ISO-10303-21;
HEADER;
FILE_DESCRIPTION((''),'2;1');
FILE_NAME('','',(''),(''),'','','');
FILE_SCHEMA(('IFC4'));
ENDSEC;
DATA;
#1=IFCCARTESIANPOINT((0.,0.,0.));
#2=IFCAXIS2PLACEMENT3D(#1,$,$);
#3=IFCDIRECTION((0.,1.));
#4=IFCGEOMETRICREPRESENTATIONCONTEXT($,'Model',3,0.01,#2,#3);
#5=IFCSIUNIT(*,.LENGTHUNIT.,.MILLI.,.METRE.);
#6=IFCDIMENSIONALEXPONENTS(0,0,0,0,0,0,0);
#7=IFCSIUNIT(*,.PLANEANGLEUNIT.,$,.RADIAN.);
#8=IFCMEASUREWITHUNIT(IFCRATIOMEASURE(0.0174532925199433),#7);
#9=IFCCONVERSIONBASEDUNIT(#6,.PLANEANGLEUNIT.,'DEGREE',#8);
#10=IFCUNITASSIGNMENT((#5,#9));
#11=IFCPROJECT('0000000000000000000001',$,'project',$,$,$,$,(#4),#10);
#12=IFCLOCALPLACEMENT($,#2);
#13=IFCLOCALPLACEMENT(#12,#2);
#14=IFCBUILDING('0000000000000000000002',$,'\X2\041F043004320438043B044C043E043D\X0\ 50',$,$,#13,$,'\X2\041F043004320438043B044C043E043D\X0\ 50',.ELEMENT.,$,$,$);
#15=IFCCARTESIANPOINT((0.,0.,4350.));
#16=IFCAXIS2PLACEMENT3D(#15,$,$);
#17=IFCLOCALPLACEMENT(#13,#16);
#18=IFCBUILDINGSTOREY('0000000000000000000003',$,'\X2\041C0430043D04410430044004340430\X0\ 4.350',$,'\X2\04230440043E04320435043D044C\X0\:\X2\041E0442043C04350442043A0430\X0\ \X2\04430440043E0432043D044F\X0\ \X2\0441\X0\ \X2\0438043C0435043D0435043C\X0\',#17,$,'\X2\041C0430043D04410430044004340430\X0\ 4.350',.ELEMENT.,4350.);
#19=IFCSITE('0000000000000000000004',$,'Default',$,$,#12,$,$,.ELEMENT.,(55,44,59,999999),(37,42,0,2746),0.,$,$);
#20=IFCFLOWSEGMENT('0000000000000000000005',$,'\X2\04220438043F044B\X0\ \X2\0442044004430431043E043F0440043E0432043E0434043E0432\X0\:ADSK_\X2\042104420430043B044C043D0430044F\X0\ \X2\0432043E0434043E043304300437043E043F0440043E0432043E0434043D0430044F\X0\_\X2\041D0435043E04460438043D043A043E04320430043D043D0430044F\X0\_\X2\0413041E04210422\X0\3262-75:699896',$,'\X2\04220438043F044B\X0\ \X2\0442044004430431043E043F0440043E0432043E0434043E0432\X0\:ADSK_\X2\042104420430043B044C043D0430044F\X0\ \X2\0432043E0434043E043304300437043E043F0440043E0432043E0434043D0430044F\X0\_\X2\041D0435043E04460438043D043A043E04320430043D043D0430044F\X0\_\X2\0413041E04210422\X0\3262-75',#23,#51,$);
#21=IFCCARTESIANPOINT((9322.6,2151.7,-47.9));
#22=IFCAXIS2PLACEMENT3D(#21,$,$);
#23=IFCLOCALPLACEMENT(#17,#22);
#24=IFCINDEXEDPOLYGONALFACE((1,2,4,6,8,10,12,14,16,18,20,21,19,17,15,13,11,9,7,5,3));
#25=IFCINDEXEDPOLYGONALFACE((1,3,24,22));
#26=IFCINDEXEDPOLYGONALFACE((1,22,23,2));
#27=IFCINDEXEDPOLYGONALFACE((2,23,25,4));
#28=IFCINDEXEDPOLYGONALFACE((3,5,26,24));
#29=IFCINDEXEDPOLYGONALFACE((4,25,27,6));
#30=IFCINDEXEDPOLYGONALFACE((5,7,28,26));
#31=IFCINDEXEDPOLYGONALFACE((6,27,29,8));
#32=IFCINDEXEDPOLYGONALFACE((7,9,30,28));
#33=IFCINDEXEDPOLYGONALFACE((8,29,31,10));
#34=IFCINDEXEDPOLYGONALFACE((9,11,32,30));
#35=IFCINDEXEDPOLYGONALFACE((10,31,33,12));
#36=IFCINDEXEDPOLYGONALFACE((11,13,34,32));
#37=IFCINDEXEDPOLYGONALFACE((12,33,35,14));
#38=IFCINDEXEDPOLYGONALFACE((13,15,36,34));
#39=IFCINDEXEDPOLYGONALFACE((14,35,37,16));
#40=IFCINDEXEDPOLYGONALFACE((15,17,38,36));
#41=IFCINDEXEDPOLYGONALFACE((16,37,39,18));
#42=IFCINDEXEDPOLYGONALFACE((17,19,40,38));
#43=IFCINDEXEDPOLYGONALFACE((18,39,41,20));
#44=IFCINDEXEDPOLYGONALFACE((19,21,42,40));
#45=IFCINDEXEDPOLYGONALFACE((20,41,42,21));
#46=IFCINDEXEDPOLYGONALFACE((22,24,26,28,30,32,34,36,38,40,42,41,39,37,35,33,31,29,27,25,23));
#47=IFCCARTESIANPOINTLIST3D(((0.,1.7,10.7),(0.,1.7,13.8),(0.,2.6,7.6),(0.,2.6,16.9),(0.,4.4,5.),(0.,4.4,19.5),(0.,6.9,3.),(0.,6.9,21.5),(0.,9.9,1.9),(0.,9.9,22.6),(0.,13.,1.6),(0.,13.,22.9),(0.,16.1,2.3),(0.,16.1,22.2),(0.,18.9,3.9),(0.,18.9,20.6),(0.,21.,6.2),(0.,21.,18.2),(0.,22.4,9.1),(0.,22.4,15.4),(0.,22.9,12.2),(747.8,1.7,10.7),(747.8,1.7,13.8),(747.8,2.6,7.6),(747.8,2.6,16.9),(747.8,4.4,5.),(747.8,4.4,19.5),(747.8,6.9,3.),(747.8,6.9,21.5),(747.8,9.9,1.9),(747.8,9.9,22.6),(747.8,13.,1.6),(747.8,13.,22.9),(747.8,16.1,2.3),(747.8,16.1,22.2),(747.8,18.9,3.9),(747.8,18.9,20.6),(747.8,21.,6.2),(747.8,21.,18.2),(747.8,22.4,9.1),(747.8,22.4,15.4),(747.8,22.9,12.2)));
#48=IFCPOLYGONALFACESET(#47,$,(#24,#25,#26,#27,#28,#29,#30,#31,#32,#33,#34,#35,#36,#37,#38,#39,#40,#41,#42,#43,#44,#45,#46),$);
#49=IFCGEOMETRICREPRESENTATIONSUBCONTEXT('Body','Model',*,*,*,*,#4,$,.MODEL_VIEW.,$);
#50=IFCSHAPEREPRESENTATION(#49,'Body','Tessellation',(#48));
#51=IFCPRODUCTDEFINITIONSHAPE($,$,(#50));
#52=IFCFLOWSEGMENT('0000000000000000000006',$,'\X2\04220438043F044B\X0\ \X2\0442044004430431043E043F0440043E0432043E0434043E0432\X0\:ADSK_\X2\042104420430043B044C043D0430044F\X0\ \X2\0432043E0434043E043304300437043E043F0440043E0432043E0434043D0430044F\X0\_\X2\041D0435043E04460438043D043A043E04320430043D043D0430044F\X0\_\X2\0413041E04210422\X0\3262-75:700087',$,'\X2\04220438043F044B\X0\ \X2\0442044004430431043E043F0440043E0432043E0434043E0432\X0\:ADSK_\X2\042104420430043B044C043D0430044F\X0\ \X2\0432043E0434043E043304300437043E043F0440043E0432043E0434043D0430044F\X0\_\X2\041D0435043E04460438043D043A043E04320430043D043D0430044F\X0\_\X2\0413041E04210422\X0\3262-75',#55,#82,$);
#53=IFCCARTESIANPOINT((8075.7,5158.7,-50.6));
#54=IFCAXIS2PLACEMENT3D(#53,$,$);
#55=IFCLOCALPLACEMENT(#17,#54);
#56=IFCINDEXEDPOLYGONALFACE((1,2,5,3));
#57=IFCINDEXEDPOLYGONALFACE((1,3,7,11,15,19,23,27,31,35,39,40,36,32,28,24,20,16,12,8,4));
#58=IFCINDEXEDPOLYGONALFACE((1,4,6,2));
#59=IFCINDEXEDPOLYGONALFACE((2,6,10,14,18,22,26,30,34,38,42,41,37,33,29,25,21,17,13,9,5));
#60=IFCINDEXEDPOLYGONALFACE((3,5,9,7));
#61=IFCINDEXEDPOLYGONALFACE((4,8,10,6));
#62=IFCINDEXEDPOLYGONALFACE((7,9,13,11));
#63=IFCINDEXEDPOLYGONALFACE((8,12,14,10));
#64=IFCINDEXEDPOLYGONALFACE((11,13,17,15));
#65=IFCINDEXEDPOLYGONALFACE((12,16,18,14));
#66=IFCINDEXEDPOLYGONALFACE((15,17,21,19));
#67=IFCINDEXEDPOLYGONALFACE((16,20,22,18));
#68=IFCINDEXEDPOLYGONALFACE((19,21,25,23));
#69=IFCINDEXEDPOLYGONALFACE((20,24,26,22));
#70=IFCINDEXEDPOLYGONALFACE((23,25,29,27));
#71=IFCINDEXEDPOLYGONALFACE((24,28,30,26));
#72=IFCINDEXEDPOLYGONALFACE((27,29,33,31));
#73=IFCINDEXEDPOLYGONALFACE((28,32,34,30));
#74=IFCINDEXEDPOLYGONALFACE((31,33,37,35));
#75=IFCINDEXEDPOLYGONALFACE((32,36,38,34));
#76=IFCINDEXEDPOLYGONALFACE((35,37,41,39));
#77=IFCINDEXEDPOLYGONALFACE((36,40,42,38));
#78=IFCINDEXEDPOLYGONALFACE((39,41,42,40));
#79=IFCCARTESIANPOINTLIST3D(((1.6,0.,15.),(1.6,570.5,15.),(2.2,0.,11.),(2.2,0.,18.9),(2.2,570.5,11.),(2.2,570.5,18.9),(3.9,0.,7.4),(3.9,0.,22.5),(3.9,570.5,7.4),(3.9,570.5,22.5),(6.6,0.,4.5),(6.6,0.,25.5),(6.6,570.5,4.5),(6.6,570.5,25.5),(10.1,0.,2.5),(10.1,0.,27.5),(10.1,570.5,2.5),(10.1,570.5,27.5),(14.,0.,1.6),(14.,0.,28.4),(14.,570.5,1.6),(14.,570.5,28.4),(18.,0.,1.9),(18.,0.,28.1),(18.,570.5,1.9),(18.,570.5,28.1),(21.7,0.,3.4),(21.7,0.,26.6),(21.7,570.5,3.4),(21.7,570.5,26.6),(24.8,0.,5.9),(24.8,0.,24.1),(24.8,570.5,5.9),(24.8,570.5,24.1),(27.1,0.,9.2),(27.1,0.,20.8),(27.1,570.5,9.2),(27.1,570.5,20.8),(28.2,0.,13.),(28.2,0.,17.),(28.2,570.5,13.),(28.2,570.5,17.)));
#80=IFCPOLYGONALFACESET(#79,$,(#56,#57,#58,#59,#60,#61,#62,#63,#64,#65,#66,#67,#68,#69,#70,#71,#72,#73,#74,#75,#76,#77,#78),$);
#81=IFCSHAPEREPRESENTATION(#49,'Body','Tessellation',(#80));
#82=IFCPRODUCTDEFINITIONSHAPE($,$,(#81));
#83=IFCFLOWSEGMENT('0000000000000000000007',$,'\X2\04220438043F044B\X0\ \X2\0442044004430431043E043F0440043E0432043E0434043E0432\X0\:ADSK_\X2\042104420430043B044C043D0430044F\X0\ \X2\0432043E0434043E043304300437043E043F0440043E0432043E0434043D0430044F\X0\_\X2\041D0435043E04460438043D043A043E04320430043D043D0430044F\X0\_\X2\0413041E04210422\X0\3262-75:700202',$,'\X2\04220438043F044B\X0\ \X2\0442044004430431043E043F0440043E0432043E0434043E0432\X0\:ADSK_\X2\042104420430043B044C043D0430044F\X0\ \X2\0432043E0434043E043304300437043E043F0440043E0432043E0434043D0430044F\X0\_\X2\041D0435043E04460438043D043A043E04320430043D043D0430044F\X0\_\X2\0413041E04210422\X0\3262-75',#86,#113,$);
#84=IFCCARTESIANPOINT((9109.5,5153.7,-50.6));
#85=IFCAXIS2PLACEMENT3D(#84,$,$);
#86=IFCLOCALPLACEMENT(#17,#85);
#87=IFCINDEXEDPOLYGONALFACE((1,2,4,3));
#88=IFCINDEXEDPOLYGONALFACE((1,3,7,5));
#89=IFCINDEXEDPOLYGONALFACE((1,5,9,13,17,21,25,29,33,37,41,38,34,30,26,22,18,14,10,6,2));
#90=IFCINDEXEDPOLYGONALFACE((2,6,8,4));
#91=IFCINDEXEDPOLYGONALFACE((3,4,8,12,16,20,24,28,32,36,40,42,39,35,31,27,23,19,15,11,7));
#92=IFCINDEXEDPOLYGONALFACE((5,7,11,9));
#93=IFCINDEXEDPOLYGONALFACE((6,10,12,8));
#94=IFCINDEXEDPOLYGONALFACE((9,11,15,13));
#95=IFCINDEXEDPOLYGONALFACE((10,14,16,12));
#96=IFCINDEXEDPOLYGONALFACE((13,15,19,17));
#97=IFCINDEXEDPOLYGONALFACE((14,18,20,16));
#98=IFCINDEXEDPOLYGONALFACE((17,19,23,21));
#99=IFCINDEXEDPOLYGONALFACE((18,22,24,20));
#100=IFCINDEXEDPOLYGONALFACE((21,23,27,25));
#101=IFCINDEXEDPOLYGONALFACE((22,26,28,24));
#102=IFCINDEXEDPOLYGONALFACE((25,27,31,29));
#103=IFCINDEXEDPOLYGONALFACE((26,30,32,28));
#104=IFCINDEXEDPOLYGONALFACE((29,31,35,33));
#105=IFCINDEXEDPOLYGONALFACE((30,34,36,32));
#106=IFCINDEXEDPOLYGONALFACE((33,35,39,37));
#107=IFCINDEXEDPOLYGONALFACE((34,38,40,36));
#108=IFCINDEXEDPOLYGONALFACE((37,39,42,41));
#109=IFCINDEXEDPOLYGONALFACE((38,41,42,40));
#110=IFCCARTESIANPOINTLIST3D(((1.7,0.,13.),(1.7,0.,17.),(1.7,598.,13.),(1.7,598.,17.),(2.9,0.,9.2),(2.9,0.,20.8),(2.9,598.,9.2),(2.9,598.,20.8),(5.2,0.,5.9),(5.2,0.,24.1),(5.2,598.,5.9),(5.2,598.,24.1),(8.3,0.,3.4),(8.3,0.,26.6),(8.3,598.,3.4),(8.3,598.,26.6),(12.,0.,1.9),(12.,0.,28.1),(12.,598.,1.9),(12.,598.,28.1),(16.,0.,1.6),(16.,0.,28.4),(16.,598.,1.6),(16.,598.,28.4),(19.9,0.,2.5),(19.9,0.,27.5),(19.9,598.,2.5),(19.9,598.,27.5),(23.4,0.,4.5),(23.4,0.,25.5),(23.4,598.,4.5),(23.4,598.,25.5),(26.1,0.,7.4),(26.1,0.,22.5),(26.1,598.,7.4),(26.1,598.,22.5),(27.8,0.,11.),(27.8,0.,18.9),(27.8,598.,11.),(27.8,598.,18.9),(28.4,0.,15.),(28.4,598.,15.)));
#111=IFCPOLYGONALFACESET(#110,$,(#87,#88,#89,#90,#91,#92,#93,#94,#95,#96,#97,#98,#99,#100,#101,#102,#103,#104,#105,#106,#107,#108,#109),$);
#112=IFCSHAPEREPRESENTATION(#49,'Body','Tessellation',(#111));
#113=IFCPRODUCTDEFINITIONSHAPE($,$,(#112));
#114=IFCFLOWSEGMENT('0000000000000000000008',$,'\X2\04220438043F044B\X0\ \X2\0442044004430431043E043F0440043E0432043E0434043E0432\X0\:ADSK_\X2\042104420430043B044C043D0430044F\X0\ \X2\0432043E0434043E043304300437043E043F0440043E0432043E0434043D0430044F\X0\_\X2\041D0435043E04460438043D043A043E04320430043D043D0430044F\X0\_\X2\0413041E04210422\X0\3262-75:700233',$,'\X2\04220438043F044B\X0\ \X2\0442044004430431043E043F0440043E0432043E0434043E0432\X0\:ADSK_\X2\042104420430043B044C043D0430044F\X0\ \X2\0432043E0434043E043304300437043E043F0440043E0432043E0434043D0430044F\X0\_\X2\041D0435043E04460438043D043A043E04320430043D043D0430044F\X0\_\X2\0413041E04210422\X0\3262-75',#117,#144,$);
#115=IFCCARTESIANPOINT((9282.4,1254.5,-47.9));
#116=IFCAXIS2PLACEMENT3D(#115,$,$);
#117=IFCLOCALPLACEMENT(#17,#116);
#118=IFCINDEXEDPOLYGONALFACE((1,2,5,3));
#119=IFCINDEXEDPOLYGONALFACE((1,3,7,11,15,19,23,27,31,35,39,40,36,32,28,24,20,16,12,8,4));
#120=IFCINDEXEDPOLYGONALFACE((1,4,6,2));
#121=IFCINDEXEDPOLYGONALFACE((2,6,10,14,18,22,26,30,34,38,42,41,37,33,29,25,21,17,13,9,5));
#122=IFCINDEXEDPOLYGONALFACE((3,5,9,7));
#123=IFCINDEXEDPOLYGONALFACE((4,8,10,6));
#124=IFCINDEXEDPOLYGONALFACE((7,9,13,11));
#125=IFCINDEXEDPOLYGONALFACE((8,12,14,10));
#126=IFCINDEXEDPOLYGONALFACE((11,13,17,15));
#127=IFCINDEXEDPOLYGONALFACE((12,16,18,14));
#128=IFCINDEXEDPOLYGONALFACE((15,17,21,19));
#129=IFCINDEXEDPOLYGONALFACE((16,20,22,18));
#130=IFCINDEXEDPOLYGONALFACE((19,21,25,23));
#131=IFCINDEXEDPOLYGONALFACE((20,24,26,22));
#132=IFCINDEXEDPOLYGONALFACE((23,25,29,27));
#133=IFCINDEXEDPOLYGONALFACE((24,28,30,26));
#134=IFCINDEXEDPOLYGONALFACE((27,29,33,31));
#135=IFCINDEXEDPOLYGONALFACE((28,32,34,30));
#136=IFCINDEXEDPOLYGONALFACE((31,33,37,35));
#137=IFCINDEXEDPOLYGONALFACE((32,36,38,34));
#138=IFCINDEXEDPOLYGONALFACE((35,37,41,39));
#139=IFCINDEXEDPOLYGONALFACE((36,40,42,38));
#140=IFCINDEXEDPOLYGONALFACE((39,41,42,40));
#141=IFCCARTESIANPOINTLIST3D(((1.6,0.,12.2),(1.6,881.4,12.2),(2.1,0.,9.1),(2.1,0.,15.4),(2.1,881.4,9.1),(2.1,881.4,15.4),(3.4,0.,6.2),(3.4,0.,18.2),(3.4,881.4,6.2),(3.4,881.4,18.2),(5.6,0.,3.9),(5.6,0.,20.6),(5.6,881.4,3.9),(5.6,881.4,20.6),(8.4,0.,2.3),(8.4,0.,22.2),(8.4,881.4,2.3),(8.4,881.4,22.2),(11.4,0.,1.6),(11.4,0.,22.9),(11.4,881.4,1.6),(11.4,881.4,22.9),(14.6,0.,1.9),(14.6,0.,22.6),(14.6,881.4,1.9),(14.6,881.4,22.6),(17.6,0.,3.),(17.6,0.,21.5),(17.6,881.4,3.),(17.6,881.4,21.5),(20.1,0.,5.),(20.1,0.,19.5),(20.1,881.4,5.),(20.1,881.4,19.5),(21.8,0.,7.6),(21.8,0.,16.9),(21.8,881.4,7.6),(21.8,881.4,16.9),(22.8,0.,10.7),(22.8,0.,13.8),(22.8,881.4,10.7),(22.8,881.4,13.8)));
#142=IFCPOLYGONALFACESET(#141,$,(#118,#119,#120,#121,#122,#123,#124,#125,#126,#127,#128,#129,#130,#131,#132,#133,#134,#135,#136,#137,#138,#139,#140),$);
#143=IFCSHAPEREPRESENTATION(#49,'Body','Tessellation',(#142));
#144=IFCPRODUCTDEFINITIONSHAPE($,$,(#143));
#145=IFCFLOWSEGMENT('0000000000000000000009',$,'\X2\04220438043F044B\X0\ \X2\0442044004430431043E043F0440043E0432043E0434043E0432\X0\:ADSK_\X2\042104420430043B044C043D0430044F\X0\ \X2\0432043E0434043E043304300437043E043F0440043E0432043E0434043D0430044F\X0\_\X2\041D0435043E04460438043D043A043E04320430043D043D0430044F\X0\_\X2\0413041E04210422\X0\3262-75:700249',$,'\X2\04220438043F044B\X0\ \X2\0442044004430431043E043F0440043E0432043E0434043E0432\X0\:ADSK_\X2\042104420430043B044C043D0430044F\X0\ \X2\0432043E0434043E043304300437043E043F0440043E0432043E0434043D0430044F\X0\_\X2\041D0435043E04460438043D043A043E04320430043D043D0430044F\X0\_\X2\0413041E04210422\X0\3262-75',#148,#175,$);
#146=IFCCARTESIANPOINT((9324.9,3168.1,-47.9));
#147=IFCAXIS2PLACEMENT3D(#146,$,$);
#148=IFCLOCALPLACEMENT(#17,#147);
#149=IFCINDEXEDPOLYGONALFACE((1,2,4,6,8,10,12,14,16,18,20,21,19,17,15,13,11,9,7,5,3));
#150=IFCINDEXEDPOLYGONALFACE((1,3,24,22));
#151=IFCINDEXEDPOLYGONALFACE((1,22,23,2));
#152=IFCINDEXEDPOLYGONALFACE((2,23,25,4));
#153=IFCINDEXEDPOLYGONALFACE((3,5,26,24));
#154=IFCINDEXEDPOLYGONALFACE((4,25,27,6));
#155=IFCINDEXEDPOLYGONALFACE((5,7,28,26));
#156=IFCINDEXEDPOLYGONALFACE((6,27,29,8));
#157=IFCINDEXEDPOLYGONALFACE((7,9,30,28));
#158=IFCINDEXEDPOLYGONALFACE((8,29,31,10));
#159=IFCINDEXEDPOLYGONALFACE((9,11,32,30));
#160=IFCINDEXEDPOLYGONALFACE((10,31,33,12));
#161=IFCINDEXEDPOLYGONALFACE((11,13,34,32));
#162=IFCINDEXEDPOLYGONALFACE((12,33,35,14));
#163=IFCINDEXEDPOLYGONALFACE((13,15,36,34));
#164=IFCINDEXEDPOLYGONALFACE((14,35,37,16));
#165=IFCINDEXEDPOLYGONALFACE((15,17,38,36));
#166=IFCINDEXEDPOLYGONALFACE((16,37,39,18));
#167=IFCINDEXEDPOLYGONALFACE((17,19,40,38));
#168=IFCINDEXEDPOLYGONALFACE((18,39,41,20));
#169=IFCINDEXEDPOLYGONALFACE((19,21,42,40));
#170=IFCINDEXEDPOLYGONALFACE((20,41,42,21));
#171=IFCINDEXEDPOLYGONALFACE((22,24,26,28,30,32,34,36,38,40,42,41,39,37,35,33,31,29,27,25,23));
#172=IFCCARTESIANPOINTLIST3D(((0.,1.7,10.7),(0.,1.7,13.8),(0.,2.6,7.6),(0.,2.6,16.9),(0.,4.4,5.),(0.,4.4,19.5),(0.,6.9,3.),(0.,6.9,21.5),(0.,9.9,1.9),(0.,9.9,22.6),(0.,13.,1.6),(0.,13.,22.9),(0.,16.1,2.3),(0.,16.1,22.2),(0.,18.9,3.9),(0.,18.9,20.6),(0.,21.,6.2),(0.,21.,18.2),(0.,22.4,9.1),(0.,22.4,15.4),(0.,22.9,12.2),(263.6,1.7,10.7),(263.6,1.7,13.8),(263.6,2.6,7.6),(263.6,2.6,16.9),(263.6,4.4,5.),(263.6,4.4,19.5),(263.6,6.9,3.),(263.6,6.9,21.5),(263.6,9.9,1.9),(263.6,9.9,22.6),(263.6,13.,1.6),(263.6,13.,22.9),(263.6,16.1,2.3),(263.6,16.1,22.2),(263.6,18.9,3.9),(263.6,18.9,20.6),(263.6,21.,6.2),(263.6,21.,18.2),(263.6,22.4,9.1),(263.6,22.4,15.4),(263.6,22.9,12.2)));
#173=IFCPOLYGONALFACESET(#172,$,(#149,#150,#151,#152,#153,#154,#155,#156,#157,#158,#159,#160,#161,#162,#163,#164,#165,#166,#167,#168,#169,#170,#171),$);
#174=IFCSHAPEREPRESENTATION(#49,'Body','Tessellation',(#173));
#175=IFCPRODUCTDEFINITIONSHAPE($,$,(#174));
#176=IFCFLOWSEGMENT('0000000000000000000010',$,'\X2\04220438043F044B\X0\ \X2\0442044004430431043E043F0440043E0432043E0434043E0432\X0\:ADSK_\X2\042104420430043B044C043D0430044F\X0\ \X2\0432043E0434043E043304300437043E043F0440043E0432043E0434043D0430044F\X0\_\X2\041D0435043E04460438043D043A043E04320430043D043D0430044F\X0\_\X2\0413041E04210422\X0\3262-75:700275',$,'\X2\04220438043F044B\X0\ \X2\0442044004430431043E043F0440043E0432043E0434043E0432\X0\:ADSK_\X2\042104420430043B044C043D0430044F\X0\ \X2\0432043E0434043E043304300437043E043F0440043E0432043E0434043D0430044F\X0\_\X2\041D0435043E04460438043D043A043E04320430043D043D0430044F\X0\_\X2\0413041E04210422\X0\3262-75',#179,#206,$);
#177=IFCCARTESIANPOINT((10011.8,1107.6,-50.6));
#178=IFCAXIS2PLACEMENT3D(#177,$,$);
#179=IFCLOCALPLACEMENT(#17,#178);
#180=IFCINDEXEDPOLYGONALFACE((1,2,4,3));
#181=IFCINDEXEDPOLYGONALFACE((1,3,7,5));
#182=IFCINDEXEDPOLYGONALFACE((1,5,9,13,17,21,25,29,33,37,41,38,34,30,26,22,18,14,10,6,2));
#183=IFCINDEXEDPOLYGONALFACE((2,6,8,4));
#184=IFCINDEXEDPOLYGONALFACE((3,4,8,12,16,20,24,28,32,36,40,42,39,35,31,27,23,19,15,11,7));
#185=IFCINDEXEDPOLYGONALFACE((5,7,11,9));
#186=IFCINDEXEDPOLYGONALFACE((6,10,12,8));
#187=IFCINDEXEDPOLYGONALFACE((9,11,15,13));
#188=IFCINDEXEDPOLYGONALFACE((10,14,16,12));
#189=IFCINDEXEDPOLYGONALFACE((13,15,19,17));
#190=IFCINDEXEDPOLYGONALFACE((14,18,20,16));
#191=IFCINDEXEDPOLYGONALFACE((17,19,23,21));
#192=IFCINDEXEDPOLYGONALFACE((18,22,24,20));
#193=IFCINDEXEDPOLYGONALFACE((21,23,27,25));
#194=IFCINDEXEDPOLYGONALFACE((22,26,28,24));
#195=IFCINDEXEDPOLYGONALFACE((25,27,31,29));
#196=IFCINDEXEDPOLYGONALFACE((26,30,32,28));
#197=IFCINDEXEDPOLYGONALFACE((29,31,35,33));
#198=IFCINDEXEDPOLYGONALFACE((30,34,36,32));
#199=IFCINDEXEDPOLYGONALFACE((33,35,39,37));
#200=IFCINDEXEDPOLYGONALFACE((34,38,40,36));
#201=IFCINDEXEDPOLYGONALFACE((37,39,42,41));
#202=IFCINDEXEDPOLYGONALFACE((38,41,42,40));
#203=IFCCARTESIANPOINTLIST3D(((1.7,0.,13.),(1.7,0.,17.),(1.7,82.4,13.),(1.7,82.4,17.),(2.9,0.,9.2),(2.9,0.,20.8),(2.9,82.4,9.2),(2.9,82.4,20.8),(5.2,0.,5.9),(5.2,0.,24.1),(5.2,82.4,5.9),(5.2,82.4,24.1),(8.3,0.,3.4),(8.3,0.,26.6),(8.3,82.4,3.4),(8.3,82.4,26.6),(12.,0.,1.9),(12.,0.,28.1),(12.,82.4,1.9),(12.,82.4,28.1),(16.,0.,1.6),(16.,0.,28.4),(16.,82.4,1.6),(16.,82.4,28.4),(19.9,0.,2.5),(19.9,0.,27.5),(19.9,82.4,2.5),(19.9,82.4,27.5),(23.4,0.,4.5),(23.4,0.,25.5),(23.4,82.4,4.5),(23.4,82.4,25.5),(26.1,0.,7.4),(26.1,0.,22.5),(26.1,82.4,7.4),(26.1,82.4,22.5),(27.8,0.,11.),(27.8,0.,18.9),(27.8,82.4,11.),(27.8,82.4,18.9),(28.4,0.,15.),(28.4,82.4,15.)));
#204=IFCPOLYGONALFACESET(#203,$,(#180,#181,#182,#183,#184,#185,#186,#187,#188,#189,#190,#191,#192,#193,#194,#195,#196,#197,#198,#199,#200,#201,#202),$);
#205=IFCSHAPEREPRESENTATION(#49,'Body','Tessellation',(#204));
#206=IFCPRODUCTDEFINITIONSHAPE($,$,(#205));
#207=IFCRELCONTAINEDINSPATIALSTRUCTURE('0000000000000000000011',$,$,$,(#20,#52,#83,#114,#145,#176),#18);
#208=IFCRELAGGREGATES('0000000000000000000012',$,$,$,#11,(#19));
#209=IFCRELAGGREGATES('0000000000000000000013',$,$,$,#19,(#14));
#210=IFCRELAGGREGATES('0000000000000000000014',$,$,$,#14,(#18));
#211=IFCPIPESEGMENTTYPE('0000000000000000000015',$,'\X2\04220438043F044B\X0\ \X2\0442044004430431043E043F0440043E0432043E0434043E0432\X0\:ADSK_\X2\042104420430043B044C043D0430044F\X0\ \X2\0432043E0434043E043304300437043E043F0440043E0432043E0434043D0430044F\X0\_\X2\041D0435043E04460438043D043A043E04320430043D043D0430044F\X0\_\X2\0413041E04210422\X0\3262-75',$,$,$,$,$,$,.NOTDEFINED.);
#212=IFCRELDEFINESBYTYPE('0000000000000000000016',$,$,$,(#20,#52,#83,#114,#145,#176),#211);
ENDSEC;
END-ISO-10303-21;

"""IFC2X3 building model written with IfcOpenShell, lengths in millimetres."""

from ifc_helpers import new_model, entity, si_unit, converted_unit, direction, frame, frame_2d, origin, origin_2d_with_axis, place, context, subcontext, project, spatial, circle, extrude, type_object, element, save


model = new_model("IFC2X3")

# Units and contexts
model_context = context("Model", 3, precision=0.01, world=origin(), true_north=direction((0.0, 1.0)))
body_context = subcontext(model_context, "Body", "Model", "MODEL_VIEW")
ifc_project = project(units=[si_unit("LENGTHUNIT", "METRE", prefix="MILLI"), converted_unit("PLANEANGLEUNIT", "DEGREE", entity("IfcRatioMeasure", 0.0174532925199433), si_unit("PLANEANGLEUNIT", "RADIAN"), dimensions=[0, 0, 0, 0, 0, 0, 0])], contexts=[model_context])

# Site, building, storey
site_placement = place(None, origin())
site = spatial("IfcSite", under=ifc_project, at=site_placement, Name="Default", CompositionType="ELEMENT", RefLatitude=(55, 44, 59, 999999), RefLongitude=(37, 42, 0, 2746), RefElevation=0.0)
building_placement = place(site_placement, origin())
building = spatial("IfcBuilding", under=site, at=building_placement, Name="Павильон 50", LongName="Павильон 50", CompositionType="ELEMENT")
storey_placement = place(building_placement, frame((0.0, 0.0, 4350.0)))
storey = spatial("IfcBuildingStorey", under=building, at=storey_placement, Name="Мансарда 4.350", ObjectType="Уровень:Отметка уровня с именем", LongName="Мансарда 4.350", CompositionType="ELEMENT", Elevation=4350.0)

# Flow segments
pipe_segment_type = type_object("IfcPipeSegmentType", Name="Типы трубопроводов:ADSK_Стальная водогазопроводная_Неоцинкованная_ГОСТ3262-75", PredefinedType="NOTDEFINED")
flow_segment_1_placement = place(storey_placement, frame((9322.6, 2151.7, -47.9)))
element("IfcFlowSegment", 1, at=flow_segment_1_placement, inside=storey, type_object=pipe_segment_type, Name="Типы трубопроводов:ADSK_Стальная водогазопроводная_Неоцинкованная_ГОСТ3262-75:699896", ObjectType="Типы трубопроводов:ADSK_Стальная водогазопроводная_Неоцинкованная_ГОСТ3262-75", context=body_context, shape_type="SweptSolid", body=[
    extrude(circle(Radius=10.7, at=origin_2d_with_axis()), frame((0.0, 12.2, 12.2), z_axis=(1.0, 0.0, 0.0), x_axis=(0.0, 1.0, 0.0)), (0.0, 0.0, 1.0), 747.8),
])
flow_segment_2_placement = place(storey_placement, frame((8075.7, 5158.7, -50.6)))
element("IfcFlowSegment", 2, at=flow_segment_2_placement, inside=storey, type_object=pipe_segment_type, Name="Типы трубопроводов:ADSK_Стальная водогазопроводная_Неоцинкованная_ГОСТ3262-75:700087", ObjectType="Типы трубопроводов:ADSK_Стальная водогазопроводная_Неоцинкованная_ГОСТ3262-75", context=body_context, shape_type="SweptSolid", body=[
    extrude(circle(Radius=13.4, at=origin_2d_with_axis()), frame((15.0, 0.0, 15.0), z_axis=(0.0, 1.0, 0.0), x_axis=(-1.0, 0.0, 0.0)), (0.0, 0.0, 1.0), 570.5),
])
flow_segment_3_placement = place(storey_placement, frame((9109.5, 5153.7, -50.6)))
element("IfcFlowSegment", 3, at=flow_segment_3_placement, inside=storey, type_object=pipe_segment_type, Name="Типы трубопроводов:ADSK_Стальная водогазопроводная_Неоцинкованная_ГОСТ3262-75:700202", ObjectType="Типы трубопроводов:ADSK_Стальная водогазопроводная_Неоцинкованная_ГОСТ3262-75", context=body_context, shape_type="SweptSolid", body=[
    extrude(circle(Radius=13.4, at=frame_2d((0.0, 0.0), x_axis=(1.0, 0.0))), frame((15.0, 0.0, 15.0), z_axis=(0.0, 1.0, 0.0), x_axis=(1.0, 0.0, 0.0)), (0.0, 0.0, 1.0), 598.0),
])
flow_segment_4_placement = place(storey_placement, frame((9282.4, 1254.5, -47.9)))
element("IfcFlowSegment", 4, at=flow_segment_4_placement, inside=storey, type_object=pipe_segment_type, Name="Типы трубопроводов:ADSK_Стальная водогазопроводная_Неоцинкованная_ГОСТ3262-75:700233", ObjectType="Типы трубопроводов:ADSK_Стальная водогазопроводная_Неоцинкованная_ГОСТ3262-75", context=body_context, shape_type="SweptSolid", body=[
    extrude(circle(Radius=10.7, at=frame_2d((0.0, 0.0), x_axis=(1.0, 0.0))), frame((12.2, 0.0, 12.2), z_axis=(0.0, 1.0, 0.0), x_axis=(-1.0, 0.0, 0.0)), (0.0, 0.0, 1.0), 881.4),
])
flow_segment_5_placement = place(storey_placement, frame((9324.9, 3168.1, -47.9)))
element("IfcFlowSegment", 5, at=flow_segment_5_placement, inside=storey, type_object=pipe_segment_type, Name="Типы трубопроводов:ADSK_Стальная водогазопроводная_Неоцинкованная_ГОСТ3262-75:700249", ObjectType="Типы трубопроводов:ADSK_Стальная водогазопроводная_Неоцинкованная_ГОСТ3262-75", context=body_context, shape_type="SweptSolid", body=[
    extrude(circle(Radius=10.7, at=origin_2d_with_axis()), frame((0.0, 12.2, 12.2), z_axis=(1.0, 0.0, 0.0), x_axis=(0.0, 1.0, 0.0)), (0.0, 0.0, 1.0), 263.6),
])
flow_segment_6_placement = place(storey_placement, frame((10011.8, 1107.6, -50.6)))
element("IfcFlowSegment", 6, at=flow_segment_6_placement, inside=storey, type_object=pipe_segment_type, Name="Типы трубопроводов:ADSK_Стальная водогазопроводная_Неоцинкованная_ГОСТ3262-75:700275", ObjectType="Типы трубопроводов:ADSK_Стальная водогазопроводная_Неоцинкованная_ГОСТ3262-75", context=body_context, shape_type="SweptSolid", body=[
    extrude(circle(Radius=13.4, at=origin_2d_with_axis()), frame((15.0, 0.0, 15.0), z_axis=(0.0, 1.0, 0.0), x_axis=(1.0, 0.0, 0.0)), (0.0, 0.0, 1.0), 82.4),
])

save(model, "model.ifc")
